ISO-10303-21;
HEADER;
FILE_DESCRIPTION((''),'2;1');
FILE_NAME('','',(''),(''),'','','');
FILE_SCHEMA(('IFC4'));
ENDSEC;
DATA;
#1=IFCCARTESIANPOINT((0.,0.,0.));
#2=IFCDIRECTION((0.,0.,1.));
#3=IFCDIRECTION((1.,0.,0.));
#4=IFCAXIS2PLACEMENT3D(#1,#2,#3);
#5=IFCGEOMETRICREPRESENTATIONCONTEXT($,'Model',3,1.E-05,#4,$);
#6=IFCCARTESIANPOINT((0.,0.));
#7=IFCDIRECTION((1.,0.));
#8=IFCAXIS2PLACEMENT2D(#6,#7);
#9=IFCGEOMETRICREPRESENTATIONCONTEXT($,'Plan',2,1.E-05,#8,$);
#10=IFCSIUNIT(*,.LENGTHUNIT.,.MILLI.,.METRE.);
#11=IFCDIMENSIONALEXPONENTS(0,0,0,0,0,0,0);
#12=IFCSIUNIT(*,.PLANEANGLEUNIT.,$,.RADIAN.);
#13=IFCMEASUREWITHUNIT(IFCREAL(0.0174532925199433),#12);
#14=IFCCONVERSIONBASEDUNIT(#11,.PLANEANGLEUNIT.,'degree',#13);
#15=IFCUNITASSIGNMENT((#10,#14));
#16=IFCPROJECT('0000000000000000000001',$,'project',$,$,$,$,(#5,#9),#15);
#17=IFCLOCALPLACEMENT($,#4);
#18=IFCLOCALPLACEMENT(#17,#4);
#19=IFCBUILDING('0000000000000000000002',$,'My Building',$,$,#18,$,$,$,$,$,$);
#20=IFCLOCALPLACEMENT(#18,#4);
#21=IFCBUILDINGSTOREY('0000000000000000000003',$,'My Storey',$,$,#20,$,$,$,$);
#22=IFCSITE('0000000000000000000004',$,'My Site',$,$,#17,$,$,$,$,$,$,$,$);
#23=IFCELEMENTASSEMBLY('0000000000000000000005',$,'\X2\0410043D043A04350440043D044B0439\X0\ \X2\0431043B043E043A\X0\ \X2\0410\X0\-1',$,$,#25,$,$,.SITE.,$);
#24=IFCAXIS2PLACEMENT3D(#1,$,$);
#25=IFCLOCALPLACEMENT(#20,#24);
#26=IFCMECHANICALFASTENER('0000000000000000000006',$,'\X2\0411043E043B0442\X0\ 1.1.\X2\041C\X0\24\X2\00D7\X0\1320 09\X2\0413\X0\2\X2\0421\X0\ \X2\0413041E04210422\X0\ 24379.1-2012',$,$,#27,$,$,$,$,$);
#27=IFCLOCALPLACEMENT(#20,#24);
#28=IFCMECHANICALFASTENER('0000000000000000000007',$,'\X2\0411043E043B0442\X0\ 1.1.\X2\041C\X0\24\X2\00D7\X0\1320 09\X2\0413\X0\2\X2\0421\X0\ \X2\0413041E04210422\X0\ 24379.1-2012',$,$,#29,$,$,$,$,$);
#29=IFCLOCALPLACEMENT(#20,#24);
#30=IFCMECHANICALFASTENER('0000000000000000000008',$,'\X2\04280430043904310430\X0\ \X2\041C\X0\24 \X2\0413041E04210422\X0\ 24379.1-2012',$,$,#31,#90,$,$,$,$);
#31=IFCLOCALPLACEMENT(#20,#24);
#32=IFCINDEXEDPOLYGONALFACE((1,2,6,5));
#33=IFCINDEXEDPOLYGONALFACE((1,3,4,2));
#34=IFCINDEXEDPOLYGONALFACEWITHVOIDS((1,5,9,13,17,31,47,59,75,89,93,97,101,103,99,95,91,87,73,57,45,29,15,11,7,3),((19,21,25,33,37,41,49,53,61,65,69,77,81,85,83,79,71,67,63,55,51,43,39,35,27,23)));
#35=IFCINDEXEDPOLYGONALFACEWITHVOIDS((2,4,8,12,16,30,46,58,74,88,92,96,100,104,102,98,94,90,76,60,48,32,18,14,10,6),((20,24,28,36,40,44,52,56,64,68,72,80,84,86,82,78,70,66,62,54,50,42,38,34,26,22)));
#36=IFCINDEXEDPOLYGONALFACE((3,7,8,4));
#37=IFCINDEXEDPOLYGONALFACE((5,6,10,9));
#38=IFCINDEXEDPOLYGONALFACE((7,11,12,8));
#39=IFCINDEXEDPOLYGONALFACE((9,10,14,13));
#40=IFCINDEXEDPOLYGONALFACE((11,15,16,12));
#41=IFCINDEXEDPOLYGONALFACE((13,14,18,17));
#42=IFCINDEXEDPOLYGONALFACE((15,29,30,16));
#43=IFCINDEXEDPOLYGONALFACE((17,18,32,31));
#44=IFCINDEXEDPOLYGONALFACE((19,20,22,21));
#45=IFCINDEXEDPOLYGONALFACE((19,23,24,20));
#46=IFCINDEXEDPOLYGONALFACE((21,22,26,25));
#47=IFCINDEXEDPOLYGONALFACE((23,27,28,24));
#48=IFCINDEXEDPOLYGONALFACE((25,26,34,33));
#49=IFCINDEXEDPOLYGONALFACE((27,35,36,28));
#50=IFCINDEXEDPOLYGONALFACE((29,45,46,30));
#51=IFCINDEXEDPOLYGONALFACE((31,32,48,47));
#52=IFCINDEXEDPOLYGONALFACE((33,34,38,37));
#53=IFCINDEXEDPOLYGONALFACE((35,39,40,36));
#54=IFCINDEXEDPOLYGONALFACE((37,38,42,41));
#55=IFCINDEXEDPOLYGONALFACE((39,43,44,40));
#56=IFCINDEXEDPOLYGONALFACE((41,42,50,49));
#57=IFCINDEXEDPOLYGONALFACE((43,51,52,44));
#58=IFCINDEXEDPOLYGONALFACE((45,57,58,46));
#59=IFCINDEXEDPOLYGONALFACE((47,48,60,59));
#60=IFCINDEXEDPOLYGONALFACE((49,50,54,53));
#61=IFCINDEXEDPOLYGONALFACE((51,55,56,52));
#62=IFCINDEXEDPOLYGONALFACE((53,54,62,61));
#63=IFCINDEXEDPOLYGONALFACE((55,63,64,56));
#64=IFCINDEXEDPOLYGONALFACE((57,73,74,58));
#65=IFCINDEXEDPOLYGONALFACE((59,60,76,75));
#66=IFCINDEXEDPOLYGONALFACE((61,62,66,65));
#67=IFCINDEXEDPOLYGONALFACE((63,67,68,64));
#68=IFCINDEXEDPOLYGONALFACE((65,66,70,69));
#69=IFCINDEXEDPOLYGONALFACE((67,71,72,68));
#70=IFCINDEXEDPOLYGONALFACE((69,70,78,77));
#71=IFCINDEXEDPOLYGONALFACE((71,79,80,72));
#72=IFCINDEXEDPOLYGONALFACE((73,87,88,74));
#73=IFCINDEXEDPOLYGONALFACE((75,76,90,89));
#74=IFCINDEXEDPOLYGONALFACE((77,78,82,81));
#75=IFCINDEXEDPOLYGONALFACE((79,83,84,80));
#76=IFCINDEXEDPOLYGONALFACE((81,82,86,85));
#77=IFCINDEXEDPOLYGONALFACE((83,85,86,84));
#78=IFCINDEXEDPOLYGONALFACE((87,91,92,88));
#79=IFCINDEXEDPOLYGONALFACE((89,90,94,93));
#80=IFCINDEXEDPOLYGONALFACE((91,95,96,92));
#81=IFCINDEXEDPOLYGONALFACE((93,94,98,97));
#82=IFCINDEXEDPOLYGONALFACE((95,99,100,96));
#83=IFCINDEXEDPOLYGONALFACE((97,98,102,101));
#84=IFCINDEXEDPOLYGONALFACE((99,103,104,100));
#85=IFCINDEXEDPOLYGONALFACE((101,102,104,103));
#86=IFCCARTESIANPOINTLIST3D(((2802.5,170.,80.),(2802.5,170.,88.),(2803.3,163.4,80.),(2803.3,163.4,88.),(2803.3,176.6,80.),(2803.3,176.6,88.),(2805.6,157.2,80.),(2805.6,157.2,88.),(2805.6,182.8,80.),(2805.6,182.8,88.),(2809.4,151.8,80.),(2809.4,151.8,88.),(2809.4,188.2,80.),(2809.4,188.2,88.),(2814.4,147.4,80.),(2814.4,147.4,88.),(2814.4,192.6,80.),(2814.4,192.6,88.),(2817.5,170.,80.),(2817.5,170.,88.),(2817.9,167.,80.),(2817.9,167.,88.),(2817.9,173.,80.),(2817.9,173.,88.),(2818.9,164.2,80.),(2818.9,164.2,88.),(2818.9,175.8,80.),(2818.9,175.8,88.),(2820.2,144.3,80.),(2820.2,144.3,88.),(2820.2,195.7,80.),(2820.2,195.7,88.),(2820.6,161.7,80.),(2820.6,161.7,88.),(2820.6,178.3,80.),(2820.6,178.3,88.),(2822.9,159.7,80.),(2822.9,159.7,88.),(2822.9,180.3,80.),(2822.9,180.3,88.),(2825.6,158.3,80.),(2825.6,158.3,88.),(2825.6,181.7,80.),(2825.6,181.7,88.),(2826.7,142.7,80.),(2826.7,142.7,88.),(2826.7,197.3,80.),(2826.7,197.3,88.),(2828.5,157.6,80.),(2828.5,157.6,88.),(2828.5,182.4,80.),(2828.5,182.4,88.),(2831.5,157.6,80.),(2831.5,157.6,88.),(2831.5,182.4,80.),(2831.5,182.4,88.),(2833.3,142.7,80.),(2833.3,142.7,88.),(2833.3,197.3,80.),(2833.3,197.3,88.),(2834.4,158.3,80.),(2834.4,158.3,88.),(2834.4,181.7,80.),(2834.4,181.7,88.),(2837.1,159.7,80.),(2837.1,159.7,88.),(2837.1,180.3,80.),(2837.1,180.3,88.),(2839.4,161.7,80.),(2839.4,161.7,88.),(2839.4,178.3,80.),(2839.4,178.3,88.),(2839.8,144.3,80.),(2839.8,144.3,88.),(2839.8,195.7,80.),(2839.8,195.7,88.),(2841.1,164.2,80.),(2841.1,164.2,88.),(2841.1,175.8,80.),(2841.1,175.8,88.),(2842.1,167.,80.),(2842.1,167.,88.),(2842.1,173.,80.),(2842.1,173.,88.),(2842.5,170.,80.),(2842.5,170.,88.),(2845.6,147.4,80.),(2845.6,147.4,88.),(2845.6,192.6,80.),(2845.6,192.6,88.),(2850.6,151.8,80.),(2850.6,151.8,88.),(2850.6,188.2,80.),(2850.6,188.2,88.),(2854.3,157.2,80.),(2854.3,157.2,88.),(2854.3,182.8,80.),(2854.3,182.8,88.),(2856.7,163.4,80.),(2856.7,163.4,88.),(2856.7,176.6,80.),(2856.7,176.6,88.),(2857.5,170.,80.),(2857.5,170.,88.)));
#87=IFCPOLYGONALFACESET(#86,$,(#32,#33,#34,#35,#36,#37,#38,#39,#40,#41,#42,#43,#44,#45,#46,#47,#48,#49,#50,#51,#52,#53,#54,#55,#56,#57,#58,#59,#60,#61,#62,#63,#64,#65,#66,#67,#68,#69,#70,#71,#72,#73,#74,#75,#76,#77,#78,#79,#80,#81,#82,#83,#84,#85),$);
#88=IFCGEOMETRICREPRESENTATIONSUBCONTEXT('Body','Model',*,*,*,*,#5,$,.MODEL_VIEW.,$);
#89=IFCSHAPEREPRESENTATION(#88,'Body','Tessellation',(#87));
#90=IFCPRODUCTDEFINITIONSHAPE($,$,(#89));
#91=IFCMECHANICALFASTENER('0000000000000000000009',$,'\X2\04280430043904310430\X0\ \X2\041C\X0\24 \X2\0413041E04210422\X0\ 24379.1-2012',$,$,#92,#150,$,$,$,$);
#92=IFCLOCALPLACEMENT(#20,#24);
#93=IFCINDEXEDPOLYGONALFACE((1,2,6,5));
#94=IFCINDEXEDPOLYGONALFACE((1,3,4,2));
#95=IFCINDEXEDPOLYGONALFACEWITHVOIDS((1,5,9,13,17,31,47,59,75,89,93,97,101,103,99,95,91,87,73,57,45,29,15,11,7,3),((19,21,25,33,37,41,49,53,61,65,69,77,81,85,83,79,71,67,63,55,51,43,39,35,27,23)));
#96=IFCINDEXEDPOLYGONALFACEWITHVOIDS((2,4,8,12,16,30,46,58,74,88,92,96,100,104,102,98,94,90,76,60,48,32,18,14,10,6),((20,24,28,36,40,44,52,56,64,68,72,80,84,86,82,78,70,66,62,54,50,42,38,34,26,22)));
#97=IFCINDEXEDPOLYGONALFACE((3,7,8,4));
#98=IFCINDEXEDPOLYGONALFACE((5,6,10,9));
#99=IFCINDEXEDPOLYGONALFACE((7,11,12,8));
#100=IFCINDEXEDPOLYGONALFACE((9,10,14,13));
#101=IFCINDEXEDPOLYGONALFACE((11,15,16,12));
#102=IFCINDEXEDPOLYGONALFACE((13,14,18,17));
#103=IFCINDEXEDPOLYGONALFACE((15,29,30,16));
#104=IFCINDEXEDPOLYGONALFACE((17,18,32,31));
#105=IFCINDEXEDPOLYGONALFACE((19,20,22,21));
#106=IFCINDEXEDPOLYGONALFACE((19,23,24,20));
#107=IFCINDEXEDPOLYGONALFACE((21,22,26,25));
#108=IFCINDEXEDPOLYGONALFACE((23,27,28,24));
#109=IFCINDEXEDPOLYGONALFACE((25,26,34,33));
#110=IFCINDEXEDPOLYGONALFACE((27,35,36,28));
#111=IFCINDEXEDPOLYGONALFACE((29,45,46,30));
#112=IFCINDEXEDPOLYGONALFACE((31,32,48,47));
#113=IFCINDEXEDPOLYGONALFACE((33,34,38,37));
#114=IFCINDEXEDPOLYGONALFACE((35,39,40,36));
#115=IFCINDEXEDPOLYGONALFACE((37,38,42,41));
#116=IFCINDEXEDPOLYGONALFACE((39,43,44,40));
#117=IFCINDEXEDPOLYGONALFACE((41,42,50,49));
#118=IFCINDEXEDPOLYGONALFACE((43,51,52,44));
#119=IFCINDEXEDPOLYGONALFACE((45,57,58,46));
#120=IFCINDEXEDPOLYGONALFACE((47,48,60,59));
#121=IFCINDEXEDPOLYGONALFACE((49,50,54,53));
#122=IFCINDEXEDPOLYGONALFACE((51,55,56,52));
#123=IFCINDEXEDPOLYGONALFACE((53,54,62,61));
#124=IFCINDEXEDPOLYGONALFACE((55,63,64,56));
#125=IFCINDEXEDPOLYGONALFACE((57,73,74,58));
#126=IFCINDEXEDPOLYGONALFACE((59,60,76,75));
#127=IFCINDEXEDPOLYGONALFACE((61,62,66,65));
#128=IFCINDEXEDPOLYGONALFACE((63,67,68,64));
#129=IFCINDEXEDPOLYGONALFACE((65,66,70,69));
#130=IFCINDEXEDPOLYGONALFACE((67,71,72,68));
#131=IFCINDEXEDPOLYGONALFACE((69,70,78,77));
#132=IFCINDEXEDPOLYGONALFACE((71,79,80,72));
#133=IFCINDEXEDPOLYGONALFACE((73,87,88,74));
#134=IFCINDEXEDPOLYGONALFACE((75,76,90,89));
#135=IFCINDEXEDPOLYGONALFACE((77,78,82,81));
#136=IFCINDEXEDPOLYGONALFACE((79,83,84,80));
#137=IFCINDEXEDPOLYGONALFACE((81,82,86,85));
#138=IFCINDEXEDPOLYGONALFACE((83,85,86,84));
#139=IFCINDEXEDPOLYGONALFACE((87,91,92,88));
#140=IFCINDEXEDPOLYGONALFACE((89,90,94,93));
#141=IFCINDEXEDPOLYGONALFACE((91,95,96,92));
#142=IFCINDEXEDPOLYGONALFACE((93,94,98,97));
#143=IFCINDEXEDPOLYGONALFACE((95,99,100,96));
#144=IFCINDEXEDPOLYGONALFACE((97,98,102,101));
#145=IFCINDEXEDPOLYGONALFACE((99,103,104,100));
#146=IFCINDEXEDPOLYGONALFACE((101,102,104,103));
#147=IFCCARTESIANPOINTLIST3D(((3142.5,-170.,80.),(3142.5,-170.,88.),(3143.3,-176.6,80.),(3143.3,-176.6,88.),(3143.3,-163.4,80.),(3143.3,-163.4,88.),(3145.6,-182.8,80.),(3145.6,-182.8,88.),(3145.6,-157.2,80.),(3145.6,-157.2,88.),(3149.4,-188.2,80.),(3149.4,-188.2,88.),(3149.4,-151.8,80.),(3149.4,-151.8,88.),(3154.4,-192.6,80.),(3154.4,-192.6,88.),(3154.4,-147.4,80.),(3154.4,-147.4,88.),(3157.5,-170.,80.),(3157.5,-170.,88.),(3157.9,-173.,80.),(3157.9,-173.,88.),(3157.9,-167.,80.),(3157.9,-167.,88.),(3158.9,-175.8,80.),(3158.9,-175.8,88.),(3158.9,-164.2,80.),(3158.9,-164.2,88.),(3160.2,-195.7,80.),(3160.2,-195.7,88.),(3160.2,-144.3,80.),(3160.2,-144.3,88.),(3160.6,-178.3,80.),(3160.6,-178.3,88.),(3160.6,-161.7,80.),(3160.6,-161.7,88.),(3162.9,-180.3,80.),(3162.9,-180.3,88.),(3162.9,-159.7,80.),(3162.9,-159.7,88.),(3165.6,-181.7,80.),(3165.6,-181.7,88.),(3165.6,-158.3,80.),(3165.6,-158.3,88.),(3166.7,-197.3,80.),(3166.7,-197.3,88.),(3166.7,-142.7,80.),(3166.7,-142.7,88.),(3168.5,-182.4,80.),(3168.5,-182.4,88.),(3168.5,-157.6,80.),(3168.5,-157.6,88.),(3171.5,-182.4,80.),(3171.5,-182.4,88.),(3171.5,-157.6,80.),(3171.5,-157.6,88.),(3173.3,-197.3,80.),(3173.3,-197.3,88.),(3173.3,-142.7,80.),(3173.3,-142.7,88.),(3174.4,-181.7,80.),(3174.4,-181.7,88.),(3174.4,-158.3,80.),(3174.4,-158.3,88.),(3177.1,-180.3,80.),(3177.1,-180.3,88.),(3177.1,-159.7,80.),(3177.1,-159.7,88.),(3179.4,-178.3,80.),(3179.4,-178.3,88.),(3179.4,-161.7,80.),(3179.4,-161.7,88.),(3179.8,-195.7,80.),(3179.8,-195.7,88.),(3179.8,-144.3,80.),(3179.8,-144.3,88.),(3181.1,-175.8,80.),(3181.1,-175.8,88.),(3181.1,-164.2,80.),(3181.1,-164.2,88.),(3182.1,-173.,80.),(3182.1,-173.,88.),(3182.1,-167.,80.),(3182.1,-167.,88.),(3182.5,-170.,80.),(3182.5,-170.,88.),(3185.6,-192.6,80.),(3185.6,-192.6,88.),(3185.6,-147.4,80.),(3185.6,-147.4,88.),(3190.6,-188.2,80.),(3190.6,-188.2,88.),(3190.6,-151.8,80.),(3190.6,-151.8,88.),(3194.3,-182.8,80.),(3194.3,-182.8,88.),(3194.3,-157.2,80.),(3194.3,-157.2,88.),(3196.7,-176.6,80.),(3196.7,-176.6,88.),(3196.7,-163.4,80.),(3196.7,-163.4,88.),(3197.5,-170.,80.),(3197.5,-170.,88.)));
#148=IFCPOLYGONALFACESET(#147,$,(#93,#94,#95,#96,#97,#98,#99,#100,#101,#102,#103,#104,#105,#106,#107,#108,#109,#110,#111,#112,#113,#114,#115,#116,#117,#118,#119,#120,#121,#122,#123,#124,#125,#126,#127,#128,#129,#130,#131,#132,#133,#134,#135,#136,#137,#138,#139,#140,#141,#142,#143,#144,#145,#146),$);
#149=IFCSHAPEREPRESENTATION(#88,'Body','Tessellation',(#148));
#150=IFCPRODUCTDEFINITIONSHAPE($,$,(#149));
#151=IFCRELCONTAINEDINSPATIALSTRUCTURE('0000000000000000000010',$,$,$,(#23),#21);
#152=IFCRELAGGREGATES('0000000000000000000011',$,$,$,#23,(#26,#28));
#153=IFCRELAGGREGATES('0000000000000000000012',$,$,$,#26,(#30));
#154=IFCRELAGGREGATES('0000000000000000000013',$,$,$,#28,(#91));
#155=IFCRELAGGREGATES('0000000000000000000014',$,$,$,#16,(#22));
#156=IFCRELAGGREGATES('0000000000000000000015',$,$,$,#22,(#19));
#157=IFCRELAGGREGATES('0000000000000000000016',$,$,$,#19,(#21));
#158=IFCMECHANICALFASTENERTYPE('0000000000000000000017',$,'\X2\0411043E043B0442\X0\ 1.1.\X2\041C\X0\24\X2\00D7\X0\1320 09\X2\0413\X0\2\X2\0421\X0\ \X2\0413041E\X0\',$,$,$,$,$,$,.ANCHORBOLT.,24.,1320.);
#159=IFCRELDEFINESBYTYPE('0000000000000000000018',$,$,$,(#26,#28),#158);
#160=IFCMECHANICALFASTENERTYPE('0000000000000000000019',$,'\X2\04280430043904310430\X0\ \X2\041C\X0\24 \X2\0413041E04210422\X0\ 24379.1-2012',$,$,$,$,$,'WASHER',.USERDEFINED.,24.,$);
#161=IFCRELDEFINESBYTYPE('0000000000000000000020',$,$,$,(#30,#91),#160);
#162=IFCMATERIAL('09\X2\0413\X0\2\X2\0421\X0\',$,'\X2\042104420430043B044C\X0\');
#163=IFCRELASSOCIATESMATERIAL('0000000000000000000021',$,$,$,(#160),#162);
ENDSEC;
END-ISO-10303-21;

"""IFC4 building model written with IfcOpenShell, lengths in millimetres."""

from ifc_helpers import new_model, entity, si_unit, converted_unit, frame, origin_with_axes, origin_2d_with_axis, place, context, subcontext, project, spatial, polyline, outline, extrude, source, transform, mapped, material, type_object, type_shapes, element, aggregate, save


model = new_model("IFC4")

# Units and contexts
model_context = context("Model", 3, precision=1e-05, world=origin_with_axes())
plan_context = context("Plan", 2, precision=1e-05, world=origin_2d_with_axis())
body_context = subcontext(model_context, "Body", "Model", "MODEL_VIEW")
ifc_project = project(units=[si_unit("LENGTHUNIT", "METRE", prefix="MILLI"), converted_unit("PLANEANGLEUNIT", "degree", entity("IfcReal", 0.0174532925199433), si_unit("PLANEANGLEUNIT", "RADIAN"), dimensions=[0, 0, 0, 0, 0, 0, 0])], contexts=[model_context, plan_context])

# Site, building, storey
site_placement = place(None, origin_with_axes())
site = spatial("IfcSite", under=ifc_project, at=site_placement, Name="My Site")
building_placement = place(site_placement, origin_with_axes())
building = spatial("IfcBuilding", under=site, at=building_placement, Name="My Building")
storey_placement = place(building_placement, origin_with_axes())
storey = spatial("IfcBuildingStorey", under=building, at=storey_placement, Name="My Storey")

# Shared definitions
placement = place(storey_placement, frame((3000.0, 0.0, 0.0), z_axis=(0.0, 0.0, 1.0), x_axis=(1.0, 0.0, 0.0)))

# Element assembly, mechanical fasteners
assembly = element("IfcElementAssembly", 1, at=placement, inside=storey, Name="Анкерный блок А-1", AssemblyPlace="SITE")
mechanical_fastener_type_1 = type_object("IfcMechanicalFastenerType", Name="Болт 1.1.М24×1320 09Г2С ГО", NominalDiameter=24.0, NominalLength=1320.0, PredefinedType="ANCHORBOLT")
mechanical_fastener_1_placement = place(placement, frame((-170.0, 170.0, 0.0), z_axis=(0.0, 0.0, 1.0), x_axis=(-1.0, 0.0, 0.0)))
mechanical_fastener_1 = element("IfcMechanicalFastener", 2, at=mechanical_fastener_1_placement, type_object=mechanical_fastener_type_1, Name="Болт 1.1.М24×1320 09Г2С ГОСТ 24379.1-2012")
ifc_material_1 = material(Name="09Г2С", Category="Сталь")
mechanical_fastener_2_placement = place(placement, frame((170.0, -170.0, 0.0), z_axis=(0.0, 0.0, 1.0), x_axis=(1.0, 0.0, 0.0)))
mechanical_fastener_2 = element("IfcMechanicalFastener", 3, at=mechanical_fastener_2_placement, type_object=mechanical_fastener_type_1, Name="Болт 1.1.М24×1320 09Г2С ГОСТ 24379.1-2012")
aggregate(assembly, [mechanical_fastener_1, mechanical_fastener_2])
mechanical_fastener_type_2 = type_object("IfcMechanicalFastenerType", Name="Шайба М24 ГОСТ 24379.1-2012", ElementType="WASHER", NominalDiameter=24.0, PredefinedType="USERDEFINED", material=ifc_material_1)
shared_shape_1 = source(origin_with_axes(), body_context, "Body", "SweptSolid", [
    extrude(outline(polyline([(27.5, 0.0), (26.7, 6.6), (24.4, 12.8), (20.6, 18.2), (15.6, 22.6), (9.8, 25.7), (3.3, 27.3), (-3.3, 27.3), (-9.8, 25.7), (-15.6, 22.6), (-20.6, 18.2), (-24.4, 12.8), (-26.7, 6.6), (-27.5, 0.0), (-26.7, -6.6), (-24.4, -12.8), (-20.6, -18.2), (-15.6, -22.6), (-9.8, -25.7), (-3.3, -27.3), (3.3, -27.3), (9.8, -25.7), (15.6, -22.6), (20.6, -18.2), (24.4, -12.8), (26.7, -6.6), (27.5, 0.0)]), holes=[polyline([(-4.4, -11.7), (-7.1, -10.3), (-9.4, -8.3), (-11.1, -5.8), (-12.1, -3.0), (-12.5, 0.0), (-12.1, 3.0), (-11.1, 5.8), (-9.4, 8.3), (-7.1, 10.3), (-4.4, 11.7), (-1.5, 12.4), (1.5, 12.4), (4.4, 11.7), (7.1, 10.3), (9.4, 8.3), (11.1, 5.8), (12.1, 3.0), (12.5, 0.0), (12.1, -3.0), (11.1, -5.8), (9.4, -8.3), (7.1, -10.3), (4.4, -11.7), (1.5, -12.4), (-1.5, -12.4), (-4.4, -11.7)])]), frame((0.0, 0.0, 0.0), z_axis=(0.0, 0.0, 1.0), x_axis=(0.120537, -0.992709, 0.0)), (0.0, 0.0, 1.0), 8.0),
])
type_shapes(mechanical_fastener_type_2, [shared_shape_1])
mechanical_fastener_3_placement = place(mechanical_fastener_1_placement, frame((0.0, 0.0, 80.0), z_axis=(0.0, 0.0, 1.0), x_axis=(1.0, 0.0, 0.0)))
mechanical_fastener_3 = element("IfcMechanicalFastener", 4, at=mechanical_fastener_3_placement, type_object=mechanical_fastener_type_2, Name="Шайба М24 ГОСТ 24379.1-2012", context=body_context, shape_type="MappedRepresentation", body=[
    mapped(shared_shape_1, transform((0.0, 0.0, 0.0), x_axis=(1.0, 0.0, 0.0), y_axis=(0.0, 1.0, 0.0), z_axis=(0.0, 0.0, 1.0), scale=1.0)),
])
aggregate(mechanical_fastener_1, [mechanical_fastener_3])
mechanical_fastener_4_placement = place(mechanical_fastener_2_placement, frame((0.0, 0.0, 80.0), z_axis=(0.0, 0.0, 1.0), x_axis=(1.0, 0.0, 0.0)))
mechanical_fastener_4 = element("IfcMechanicalFastener", 5, at=mechanical_fastener_4_placement, type_object=mechanical_fastener_type_2, Name="Шайба М24 ГОСТ 24379.1-2012", context=body_context, shape_type="MappedRepresentation", body=[
    mapped(shared_shape_1, transform((0.0, 0.0, 0.0), x_axis=(1.0, 0.0, 0.0), y_axis=(0.0, 1.0, 0.0), z_axis=(0.0, 0.0, 1.0), scale=1.0)),
])
aggregate(mechanical_fastener_2, [mechanical_fastener_4])

save(model, "model.ifc")
